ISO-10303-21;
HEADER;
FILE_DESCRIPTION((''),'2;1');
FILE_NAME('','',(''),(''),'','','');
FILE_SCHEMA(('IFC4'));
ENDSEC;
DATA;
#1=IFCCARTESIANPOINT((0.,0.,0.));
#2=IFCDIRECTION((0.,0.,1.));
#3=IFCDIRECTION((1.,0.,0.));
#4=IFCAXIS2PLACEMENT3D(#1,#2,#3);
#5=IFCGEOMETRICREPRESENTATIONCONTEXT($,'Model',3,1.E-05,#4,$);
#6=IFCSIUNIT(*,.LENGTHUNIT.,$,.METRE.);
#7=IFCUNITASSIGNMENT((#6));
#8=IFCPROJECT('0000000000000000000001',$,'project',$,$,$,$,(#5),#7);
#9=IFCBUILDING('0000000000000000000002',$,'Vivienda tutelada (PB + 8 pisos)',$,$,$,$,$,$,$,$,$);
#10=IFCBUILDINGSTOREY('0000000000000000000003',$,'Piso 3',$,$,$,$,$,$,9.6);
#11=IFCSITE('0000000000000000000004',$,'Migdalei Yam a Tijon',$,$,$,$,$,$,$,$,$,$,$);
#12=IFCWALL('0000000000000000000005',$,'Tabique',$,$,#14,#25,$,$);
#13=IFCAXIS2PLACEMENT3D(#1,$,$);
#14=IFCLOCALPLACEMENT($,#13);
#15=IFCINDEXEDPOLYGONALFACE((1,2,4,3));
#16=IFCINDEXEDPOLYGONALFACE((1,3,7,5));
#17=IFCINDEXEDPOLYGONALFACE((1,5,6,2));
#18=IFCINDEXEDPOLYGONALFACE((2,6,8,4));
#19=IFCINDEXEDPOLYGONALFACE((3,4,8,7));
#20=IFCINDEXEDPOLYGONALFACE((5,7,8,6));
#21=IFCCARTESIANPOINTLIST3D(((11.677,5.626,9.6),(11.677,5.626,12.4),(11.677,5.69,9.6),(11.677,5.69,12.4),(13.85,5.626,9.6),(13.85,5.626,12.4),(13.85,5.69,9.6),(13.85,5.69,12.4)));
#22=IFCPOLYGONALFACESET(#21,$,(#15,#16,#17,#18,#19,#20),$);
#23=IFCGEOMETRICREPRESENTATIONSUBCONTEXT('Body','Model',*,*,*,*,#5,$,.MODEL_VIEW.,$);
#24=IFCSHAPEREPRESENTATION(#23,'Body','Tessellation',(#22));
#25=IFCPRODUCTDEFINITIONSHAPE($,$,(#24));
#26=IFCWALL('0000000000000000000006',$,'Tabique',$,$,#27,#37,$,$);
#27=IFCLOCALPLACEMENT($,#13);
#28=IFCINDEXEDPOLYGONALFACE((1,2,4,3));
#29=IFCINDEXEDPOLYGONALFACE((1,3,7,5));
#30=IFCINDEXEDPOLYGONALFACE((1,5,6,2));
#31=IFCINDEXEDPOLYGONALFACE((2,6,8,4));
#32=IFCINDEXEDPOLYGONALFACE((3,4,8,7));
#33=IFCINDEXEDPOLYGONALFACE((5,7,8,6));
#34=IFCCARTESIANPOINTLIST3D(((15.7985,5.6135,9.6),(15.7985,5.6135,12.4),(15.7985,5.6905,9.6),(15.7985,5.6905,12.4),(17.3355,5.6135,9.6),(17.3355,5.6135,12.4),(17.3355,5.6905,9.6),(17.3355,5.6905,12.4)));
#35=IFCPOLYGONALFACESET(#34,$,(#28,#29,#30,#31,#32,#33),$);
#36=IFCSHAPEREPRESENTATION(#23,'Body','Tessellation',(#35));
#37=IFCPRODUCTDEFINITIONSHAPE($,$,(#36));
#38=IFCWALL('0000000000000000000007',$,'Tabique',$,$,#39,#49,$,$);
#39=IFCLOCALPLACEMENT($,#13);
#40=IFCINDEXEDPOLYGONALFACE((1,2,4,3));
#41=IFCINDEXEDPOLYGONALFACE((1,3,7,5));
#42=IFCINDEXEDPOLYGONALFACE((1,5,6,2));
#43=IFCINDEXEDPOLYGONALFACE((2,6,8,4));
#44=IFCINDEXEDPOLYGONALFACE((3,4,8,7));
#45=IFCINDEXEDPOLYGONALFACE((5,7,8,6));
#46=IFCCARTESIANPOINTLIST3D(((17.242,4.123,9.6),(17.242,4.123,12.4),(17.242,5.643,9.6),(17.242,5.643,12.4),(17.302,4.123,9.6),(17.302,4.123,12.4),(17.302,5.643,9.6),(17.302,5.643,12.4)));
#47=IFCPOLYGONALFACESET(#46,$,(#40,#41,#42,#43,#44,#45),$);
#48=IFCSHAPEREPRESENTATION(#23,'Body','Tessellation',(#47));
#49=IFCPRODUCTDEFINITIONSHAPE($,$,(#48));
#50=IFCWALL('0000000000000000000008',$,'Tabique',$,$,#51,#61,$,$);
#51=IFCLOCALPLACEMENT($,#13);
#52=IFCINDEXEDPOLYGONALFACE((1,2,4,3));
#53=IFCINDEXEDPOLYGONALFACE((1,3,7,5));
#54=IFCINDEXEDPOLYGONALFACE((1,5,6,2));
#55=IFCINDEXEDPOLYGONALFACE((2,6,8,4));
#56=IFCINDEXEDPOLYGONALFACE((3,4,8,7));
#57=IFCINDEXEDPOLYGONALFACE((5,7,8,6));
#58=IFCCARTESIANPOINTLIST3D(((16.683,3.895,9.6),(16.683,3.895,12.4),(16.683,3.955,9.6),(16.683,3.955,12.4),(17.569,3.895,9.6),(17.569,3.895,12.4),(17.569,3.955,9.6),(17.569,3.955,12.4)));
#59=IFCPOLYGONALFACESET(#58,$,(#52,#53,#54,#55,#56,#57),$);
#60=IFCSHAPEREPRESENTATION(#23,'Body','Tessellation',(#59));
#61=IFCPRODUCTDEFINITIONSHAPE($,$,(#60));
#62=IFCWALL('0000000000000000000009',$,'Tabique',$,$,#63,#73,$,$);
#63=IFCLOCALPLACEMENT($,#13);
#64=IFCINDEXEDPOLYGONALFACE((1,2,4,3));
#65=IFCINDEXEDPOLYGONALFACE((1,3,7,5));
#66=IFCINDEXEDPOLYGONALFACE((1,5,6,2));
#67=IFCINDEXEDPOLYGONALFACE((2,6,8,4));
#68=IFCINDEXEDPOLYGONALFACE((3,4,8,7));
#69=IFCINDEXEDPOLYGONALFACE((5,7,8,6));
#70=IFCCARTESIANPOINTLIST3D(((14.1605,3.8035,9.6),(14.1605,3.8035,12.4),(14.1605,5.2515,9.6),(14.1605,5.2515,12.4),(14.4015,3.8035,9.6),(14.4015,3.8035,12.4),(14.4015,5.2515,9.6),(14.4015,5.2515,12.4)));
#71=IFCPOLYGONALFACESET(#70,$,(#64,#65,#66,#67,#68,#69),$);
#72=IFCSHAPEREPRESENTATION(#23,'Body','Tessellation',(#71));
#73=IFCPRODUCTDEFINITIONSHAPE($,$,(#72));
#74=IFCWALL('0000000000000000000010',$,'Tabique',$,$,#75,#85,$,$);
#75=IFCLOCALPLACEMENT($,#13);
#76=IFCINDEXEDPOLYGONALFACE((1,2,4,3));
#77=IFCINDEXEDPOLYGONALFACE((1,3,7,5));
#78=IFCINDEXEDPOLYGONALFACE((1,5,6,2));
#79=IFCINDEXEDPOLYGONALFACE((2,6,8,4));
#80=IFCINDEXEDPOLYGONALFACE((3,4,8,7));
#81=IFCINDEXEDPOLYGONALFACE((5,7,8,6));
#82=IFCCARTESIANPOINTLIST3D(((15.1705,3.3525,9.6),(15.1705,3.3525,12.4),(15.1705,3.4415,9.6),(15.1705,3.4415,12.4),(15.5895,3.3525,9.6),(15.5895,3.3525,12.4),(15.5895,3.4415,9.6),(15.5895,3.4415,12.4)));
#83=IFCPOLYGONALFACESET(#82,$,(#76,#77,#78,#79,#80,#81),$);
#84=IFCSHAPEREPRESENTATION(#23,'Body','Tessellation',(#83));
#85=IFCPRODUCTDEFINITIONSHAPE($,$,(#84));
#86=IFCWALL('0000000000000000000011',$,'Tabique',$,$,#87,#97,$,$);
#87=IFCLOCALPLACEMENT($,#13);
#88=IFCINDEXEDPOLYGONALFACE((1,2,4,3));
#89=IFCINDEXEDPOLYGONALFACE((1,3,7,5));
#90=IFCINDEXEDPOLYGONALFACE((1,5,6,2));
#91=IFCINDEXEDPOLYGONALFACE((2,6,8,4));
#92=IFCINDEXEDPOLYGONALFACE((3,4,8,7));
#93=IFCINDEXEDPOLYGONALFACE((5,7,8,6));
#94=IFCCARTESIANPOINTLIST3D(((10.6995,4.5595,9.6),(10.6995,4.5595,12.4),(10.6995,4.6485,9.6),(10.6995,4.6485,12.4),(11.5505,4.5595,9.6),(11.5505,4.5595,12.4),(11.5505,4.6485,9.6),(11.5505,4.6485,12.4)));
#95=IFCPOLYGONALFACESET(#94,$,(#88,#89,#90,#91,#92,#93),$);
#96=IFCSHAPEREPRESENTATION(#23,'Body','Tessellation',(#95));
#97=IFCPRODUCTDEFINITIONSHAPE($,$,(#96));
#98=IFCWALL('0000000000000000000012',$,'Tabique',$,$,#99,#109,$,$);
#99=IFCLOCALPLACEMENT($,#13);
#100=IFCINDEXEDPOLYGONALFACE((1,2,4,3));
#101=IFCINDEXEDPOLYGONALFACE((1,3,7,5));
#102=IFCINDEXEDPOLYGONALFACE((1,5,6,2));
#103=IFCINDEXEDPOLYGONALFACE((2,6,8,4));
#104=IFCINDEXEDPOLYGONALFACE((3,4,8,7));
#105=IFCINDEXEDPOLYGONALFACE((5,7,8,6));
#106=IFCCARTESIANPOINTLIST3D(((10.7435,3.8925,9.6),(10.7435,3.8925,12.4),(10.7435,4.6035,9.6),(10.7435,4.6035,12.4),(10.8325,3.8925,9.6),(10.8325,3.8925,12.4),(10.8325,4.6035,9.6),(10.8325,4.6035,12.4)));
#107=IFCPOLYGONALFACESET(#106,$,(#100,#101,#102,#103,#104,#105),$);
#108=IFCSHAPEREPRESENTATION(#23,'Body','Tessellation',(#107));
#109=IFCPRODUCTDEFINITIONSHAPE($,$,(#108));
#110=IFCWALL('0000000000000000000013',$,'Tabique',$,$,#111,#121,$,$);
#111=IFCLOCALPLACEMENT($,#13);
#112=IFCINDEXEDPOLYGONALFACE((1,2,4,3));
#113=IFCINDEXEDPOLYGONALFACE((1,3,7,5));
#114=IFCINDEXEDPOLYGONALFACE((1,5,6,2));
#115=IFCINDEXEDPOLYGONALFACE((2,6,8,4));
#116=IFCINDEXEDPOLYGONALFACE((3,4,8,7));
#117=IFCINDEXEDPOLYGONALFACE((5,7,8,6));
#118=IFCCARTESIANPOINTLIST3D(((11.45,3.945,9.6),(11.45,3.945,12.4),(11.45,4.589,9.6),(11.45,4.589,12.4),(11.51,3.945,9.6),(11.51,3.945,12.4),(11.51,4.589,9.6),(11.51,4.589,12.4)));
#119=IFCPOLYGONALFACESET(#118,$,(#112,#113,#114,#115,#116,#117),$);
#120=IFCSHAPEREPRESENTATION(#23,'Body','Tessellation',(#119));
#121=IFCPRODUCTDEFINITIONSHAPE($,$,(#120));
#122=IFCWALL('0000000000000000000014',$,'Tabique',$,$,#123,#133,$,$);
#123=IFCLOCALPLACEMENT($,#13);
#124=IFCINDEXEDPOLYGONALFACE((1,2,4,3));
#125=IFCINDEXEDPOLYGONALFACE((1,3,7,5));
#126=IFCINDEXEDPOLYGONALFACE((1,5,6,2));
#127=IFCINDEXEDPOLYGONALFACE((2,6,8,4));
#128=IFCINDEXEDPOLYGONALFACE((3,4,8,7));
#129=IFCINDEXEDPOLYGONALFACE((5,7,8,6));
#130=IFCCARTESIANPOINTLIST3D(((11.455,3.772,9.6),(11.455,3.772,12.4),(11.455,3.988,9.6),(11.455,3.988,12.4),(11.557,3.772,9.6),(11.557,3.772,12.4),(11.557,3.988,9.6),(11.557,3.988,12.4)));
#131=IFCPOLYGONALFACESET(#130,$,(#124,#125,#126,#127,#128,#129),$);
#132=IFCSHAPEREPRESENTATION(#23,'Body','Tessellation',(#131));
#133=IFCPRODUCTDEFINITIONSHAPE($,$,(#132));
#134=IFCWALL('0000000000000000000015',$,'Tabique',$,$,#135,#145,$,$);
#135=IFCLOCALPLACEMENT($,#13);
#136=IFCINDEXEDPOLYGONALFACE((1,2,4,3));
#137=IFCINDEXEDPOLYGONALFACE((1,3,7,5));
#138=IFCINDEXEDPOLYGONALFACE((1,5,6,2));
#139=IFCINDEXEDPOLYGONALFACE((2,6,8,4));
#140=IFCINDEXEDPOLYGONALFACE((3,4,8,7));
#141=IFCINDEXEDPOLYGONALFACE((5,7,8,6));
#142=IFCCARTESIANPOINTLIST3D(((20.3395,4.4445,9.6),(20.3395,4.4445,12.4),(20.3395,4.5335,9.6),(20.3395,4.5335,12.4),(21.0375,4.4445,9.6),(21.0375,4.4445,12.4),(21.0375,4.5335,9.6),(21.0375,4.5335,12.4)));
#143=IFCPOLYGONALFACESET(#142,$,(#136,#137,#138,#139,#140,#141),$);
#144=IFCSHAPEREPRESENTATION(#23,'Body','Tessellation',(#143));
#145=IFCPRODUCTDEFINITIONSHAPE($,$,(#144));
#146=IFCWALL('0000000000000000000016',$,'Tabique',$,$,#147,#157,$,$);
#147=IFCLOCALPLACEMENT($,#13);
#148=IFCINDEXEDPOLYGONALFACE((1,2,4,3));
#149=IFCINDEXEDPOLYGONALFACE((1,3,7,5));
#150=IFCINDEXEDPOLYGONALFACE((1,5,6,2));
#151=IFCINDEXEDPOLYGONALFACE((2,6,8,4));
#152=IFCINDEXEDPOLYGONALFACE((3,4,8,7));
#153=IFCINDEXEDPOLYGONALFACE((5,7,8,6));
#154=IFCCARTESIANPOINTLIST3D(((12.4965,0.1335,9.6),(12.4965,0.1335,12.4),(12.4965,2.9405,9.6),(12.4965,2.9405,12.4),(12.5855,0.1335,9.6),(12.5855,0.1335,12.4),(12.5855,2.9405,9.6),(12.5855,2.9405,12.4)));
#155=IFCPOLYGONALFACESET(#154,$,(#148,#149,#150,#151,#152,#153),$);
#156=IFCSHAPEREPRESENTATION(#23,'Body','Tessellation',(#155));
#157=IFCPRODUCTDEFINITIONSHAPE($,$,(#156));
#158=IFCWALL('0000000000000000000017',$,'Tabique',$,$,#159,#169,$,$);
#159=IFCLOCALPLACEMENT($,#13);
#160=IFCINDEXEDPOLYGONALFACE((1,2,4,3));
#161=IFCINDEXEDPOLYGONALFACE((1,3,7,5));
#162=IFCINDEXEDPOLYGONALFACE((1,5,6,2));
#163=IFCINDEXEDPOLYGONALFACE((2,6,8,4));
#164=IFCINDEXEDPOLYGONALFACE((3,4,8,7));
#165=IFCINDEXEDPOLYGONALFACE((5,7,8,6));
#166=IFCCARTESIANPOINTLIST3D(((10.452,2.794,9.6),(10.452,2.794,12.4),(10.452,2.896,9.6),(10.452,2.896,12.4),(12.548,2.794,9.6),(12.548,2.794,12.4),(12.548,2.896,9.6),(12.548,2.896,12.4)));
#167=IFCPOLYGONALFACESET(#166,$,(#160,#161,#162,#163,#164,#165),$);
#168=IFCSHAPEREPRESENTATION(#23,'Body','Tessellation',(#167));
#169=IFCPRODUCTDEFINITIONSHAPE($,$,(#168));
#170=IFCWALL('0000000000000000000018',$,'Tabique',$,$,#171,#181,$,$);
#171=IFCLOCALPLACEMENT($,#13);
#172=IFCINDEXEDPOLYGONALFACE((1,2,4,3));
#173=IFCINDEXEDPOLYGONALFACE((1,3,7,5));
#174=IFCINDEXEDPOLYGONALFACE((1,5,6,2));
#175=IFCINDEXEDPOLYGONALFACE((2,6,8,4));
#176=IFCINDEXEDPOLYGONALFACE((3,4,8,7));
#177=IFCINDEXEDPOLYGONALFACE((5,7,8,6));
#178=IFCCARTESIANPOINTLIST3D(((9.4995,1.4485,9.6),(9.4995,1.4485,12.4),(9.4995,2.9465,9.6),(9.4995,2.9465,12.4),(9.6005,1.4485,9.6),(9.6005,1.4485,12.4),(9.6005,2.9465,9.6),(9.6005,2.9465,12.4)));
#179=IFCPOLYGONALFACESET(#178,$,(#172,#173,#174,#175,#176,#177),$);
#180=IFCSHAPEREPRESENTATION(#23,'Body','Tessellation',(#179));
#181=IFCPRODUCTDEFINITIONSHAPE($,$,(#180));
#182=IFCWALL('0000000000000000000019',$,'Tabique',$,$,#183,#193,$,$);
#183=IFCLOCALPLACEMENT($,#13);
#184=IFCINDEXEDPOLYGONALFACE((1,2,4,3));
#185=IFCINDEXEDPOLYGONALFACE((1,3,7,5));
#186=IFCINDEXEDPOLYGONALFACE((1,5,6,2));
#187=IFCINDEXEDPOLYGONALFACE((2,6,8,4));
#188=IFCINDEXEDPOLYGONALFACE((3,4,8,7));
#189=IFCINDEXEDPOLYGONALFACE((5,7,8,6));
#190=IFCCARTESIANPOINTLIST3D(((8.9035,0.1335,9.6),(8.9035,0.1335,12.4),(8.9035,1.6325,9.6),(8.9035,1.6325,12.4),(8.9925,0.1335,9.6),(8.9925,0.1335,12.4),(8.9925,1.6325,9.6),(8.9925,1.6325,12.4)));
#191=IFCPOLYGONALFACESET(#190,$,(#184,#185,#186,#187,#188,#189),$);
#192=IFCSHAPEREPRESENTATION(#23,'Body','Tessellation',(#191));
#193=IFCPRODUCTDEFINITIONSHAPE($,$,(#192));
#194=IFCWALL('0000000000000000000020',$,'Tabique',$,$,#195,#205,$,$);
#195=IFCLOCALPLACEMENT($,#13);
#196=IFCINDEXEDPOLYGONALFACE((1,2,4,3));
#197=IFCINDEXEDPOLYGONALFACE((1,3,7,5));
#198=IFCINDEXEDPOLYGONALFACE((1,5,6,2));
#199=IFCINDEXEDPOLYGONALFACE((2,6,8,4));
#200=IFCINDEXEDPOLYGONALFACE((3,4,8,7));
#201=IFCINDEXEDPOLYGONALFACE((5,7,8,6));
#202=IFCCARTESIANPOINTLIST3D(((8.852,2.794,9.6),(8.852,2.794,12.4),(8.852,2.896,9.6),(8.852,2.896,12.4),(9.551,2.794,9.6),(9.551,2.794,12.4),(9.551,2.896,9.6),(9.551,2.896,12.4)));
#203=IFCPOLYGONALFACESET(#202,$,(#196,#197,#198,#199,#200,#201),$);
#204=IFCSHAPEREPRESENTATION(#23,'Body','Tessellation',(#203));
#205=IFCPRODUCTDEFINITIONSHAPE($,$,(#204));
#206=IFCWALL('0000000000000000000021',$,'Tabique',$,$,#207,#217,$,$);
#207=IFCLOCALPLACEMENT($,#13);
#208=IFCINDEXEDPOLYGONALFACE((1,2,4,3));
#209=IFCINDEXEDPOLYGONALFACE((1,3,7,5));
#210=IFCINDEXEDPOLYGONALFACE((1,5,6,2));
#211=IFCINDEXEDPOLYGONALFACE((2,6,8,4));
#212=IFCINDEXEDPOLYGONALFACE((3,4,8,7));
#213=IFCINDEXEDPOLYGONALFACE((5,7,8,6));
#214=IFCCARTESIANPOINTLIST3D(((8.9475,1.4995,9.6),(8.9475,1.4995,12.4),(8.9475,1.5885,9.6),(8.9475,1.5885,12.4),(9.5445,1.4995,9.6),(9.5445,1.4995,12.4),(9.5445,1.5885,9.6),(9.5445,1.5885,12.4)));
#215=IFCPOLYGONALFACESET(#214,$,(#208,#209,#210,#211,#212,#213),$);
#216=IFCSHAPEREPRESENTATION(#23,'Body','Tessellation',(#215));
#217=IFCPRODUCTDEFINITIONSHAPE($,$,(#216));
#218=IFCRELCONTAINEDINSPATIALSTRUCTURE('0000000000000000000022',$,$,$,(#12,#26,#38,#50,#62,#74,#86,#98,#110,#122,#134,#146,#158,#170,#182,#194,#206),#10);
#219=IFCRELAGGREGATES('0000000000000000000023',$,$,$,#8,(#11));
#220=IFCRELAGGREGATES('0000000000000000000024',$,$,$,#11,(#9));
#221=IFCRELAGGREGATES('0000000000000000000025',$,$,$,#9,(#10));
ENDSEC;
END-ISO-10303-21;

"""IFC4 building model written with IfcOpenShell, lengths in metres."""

from ifc_helpers import new_model, si_unit, frame, origin_with_axes, context, subcontext, project, spatial, line, indexed_curve, outline, extrude, element, save


model = new_model("IFC4")

# Units and contexts
model_context = context("Model", 3, precision=1e-05, world=origin_with_axes())
body_context = subcontext(model_context, "Body", "Model", "MODEL_VIEW")
ifc_project = project(units=[si_unit("LENGTHUNIT", "METRE")], contexts=[model_context])

# Site, building, storey
site = spatial("IfcSite", under=ifc_project, Name="Migdalei Yam a Tijon")
building = spatial("IfcBuilding", under=site, Name="Vivienda tutelada (PB + 8 pisos)")
storey = spatial("IfcBuildingStorey", under=building, Name="Piso 3", Elevation=9.6)

# Walls
element("IfcWall", 1, inside=storey, Name="Tabique", context=body_context, shape_type="SweptSolid", body=[
    extrude(outline(indexed_curve([(0.0, 0.0), (2.173, 0.0), (2.173, 0.064), (0.0, 0.064)], segments=[line(1, 2, 3, 4, 1)])), frame((11.677, 5.626, 9.6), z_axis=(0.0, 0.0, 1.0), x_axis=(1.0, 0.0, 0.0)), (0.0, 0.0, 1.0), 2.8),
])
element("IfcWall", 2, inside=storey, Name="Tabique", context=body_context, shape_type="SweptSolid", body=[
    extrude(outline(indexed_curve([(0.0, 0.0), (1.537, 0.0), (1.537, 0.077), (0.0, 0.077)], segments=[line(1, 2, 3, 4, 1)])), frame((15.7985, 5.6135, 9.6), z_axis=(0.0, 0.0, 1.0), x_axis=(1.0, 0.0, 0.0)), (0.0, 0.0, 1.0), 2.8),
])
element("IfcWall", 3, inside=storey, Name="Tabique", context=body_context, shape_type="SweptSolid", body=[
    extrude(outline(indexed_curve([(0.0, 0.0), (0.06, 0.0), (0.06, 1.52), (0.0, 1.52)], segments=[line(1, 2, 3, 4, 1)])), frame((17.242, 4.123, 9.6), z_axis=(0.0, 0.0, 1.0), x_axis=(1.0, 0.0, 0.0)), (0.0, 0.0, 1.0), 2.8),
])
element("IfcWall", 4, inside=storey, Name="Tabique", context=body_context, shape_type="SweptSolid", body=[
    extrude(outline(indexed_curve([(0.0, 0.0), (0.886, 0.0), (0.886, 0.06), (0.0, 0.06)], segments=[line(1, 2, 3, 4, 1)])), frame((16.683, 3.895, 9.6), z_axis=(0.0, 0.0, 1.0), x_axis=(1.0, 0.0, 0.0)), (0.0, 0.0, 1.0), 2.8),
])
element("IfcWall", 5, inside=storey, Name="Tabique", context=body_context, shape_type="SweptSolid", body=[
    extrude(outline(indexed_curve([(0.0, 0.0), (0.241, 0.0), (0.241, 1.448), (0.0, 1.448)], segments=[line(1, 2, 3, 4, 1)])), frame((14.1605, 3.8035, 9.6), z_axis=(0.0, 0.0, 1.0), x_axis=(1.0, 0.0, 0.0)), (0.0, 0.0, 1.0), 2.8),
])
element("IfcWall", 6, inside=storey, Name="Tabique", context=body_context, shape_type="SweptSolid", body=[
    extrude(outline(indexed_curve([(0.0, 0.0), (0.419, 0.0), (0.419, 0.089), (0.0, 0.089)], segments=[line(1, 2, 3, 4, 1)])), frame((15.1705, 3.3525, 9.6), z_axis=(0.0, 0.0, 1.0), x_axis=(1.0, 0.0, 0.0)), (0.0, 0.0, 1.0), 2.8),
])
element("IfcWall", 7, inside=storey, Name="Tabique", context=body_context, shape_type="SweptSolid", body=[
    extrude(outline(indexed_curve([(0.0, 0.0), (0.851, 0.0), (0.851, 0.089), (0.0, 0.089)], segments=[line(1, 2, 3, 4, 1)])), frame((10.6995, 4.5595, 9.6), z_axis=(0.0, 0.0, 1.0), x_axis=(1.0, 0.0, 0.0)), (0.0, 0.0, 1.0), 2.8),
])
element("IfcWall", 8, inside=storey, Name="Tabique", context=body_context, shape_type="SweptSolid", body=[
    extrude(outline(indexed_curve([(0.0, 0.0), (0.089, 0.0), (0.089, 0.711), (0.0, 0.711)], segments=[line(1, 2, 3, 4, 1)])), frame((10.7435, 3.8925, 9.6), z_axis=(0.0, 0.0, 1.0), x_axis=(1.0, 0.0, 0.0)), (0.0, 0.0, 1.0), 2.8),
])
element("IfcWall", 9, inside=storey, Name="Tabique", context=body_context, shape_type="SweptSolid", body=[
    extrude(outline(indexed_curve([(0.0, 0.0), (0.06, 0.0), (0.06, 0.644), (0.0, 0.644)], segments=[line(1, 2, 3, 4, 1)])), frame((11.45, 3.945, 9.6), z_axis=(0.0, 0.0, 1.0), x_axis=(1.0, 0.0, 0.0)), (0.0, 0.0, 1.0), 2.8),
])
element("IfcWall", 10, inside=storey, Name="Tabique", context=body_context, shape_type="SweptSolid", body=[
    extrude(outline(indexed_curve([(0.0, 0.0), (0.102, 0.0), (0.102, 0.216), (0.0, 0.216)], segments=[line(1, 2, 3, 4, 1)])), frame((11.455, 3.772, 9.6), z_axis=(0.0, 0.0, 1.0), x_axis=(1.0, 0.0, 0.0)), (0.0, 0.0, 1.0), 2.8),
])
element("IfcWall", 11, inside=storey, Name="Tabique", context=body_context, shape_type="SweptSolid", body=[
    extrude(outline(indexed_curve([(0.0, 0.0), (0.698, 0.0), (0.698, 0.089), (0.0, 0.089)], segments=[line(1, 2, 3, 4, 1)])), frame((20.3395, 4.4445, 9.6), z_axis=(0.0, 0.0, 1.0), x_axis=(1.0, 0.0, 0.0)), (0.0, 0.0, 1.0), 2.8),
])
element("IfcWall", 12, inside=storey, Name="Tabique", context=body_context, shape_type="SweptSolid", body=[
    extrude(outline(indexed_curve([(0.0, 0.0), (0.089, 0.0), (0.089, 2.807), (0.0, 2.807)], segments=[line(1, 2, 3, 4, 1)])), frame((12.4965, 0.1335, 9.6), z_axis=(0.0, 0.0, 1.0), x_axis=(1.0, 0.0, 0.0)), (0.0, 0.0, 1.0), 2.8),
])
element("IfcWall", 13, inside=storey, Name="Tabique", context=body_context, shape_type="SweptSolid", body=[
    extrude(outline(indexed_curve([(0.0, 0.0), (2.096, 0.0), (2.096, 0.102), (0.0, 0.102)], segments=[line(1, 2, 3, 4, 1)])), frame((10.452, 2.794, 9.6), z_axis=(0.0, 0.0, 1.0), x_axis=(1.0, 0.0, 0.0)), (0.0, 0.0, 1.0), 2.8),
])
element("IfcWall", 14, inside=storey, Name="Tabique", context=body_context, shape_type="SweptSolid", body=[
    extrude(outline(indexed_curve([(0.0, 0.0), (0.101, 0.0), (0.101, 1.498), (0.0, 1.498)], segments=[line(1, 2, 3, 4, 1)])), frame((9.4995, 1.4485, 9.6), z_axis=(0.0, 0.0, 1.0), x_axis=(1.0, 0.0, 0.0)), (0.0, 0.0, 1.0), 2.8),
])
element("IfcWall", 15, inside=storey, Name="Tabique", context=body_context, shape_type="SweptSolid", body=[
    extrude(outline(indexed_curve([(0.0, 0.0), (0.089, 0.0), (0.089, 1.499), (0.0, 1.499)], segments=[line(1, 2, 3, 4, 1)])), frame((8.9035, 0.1335, 9.6), z_axis=(0.0, 0.0, 1.0), x_axis=(1.0, 0.0, 0.0)), (0.0, 0.0, 1.0), 2.8),
])
element("IfcWall", 16, inside=storey, Name="Tabique", context=body_context, shape_type="SweptSolid", body=[
    extrude(outline(indexed_curve([(0.0, 0.0), (0.699, 0.0), (0.699, 0.102), (0.0, 0.102)], segments=[line(1, 2, 3, 4, 1)])), frame((8.852, 2.794, 9.6), z_axis=(0.0, 0.0, 1.0), x_axis=(1.0, 0.0, 0.0)), (0.0, 0.0, 1.0), 2.8),
])
element("IfcWall", 17, inside=storey, Name="Tabique", context=body_context, shape_type="SweptSolid", body=[
    extrude(outline(indexed_curve([(0.0, 0.0), (0.597, 0.0), (0.597, 0.089), (0.0, 0.089)], segments=[line(1, 2, 3, 4, 1)])), frame((8.9475, 1.4995, 9.6), z_axis=(0.0, 0.0, 1.0), x_axis=(1.0, 0.0, 0.0)), (0.0, 0.0, 1.0), 2.8),
])

save(model, "model.ifc")
